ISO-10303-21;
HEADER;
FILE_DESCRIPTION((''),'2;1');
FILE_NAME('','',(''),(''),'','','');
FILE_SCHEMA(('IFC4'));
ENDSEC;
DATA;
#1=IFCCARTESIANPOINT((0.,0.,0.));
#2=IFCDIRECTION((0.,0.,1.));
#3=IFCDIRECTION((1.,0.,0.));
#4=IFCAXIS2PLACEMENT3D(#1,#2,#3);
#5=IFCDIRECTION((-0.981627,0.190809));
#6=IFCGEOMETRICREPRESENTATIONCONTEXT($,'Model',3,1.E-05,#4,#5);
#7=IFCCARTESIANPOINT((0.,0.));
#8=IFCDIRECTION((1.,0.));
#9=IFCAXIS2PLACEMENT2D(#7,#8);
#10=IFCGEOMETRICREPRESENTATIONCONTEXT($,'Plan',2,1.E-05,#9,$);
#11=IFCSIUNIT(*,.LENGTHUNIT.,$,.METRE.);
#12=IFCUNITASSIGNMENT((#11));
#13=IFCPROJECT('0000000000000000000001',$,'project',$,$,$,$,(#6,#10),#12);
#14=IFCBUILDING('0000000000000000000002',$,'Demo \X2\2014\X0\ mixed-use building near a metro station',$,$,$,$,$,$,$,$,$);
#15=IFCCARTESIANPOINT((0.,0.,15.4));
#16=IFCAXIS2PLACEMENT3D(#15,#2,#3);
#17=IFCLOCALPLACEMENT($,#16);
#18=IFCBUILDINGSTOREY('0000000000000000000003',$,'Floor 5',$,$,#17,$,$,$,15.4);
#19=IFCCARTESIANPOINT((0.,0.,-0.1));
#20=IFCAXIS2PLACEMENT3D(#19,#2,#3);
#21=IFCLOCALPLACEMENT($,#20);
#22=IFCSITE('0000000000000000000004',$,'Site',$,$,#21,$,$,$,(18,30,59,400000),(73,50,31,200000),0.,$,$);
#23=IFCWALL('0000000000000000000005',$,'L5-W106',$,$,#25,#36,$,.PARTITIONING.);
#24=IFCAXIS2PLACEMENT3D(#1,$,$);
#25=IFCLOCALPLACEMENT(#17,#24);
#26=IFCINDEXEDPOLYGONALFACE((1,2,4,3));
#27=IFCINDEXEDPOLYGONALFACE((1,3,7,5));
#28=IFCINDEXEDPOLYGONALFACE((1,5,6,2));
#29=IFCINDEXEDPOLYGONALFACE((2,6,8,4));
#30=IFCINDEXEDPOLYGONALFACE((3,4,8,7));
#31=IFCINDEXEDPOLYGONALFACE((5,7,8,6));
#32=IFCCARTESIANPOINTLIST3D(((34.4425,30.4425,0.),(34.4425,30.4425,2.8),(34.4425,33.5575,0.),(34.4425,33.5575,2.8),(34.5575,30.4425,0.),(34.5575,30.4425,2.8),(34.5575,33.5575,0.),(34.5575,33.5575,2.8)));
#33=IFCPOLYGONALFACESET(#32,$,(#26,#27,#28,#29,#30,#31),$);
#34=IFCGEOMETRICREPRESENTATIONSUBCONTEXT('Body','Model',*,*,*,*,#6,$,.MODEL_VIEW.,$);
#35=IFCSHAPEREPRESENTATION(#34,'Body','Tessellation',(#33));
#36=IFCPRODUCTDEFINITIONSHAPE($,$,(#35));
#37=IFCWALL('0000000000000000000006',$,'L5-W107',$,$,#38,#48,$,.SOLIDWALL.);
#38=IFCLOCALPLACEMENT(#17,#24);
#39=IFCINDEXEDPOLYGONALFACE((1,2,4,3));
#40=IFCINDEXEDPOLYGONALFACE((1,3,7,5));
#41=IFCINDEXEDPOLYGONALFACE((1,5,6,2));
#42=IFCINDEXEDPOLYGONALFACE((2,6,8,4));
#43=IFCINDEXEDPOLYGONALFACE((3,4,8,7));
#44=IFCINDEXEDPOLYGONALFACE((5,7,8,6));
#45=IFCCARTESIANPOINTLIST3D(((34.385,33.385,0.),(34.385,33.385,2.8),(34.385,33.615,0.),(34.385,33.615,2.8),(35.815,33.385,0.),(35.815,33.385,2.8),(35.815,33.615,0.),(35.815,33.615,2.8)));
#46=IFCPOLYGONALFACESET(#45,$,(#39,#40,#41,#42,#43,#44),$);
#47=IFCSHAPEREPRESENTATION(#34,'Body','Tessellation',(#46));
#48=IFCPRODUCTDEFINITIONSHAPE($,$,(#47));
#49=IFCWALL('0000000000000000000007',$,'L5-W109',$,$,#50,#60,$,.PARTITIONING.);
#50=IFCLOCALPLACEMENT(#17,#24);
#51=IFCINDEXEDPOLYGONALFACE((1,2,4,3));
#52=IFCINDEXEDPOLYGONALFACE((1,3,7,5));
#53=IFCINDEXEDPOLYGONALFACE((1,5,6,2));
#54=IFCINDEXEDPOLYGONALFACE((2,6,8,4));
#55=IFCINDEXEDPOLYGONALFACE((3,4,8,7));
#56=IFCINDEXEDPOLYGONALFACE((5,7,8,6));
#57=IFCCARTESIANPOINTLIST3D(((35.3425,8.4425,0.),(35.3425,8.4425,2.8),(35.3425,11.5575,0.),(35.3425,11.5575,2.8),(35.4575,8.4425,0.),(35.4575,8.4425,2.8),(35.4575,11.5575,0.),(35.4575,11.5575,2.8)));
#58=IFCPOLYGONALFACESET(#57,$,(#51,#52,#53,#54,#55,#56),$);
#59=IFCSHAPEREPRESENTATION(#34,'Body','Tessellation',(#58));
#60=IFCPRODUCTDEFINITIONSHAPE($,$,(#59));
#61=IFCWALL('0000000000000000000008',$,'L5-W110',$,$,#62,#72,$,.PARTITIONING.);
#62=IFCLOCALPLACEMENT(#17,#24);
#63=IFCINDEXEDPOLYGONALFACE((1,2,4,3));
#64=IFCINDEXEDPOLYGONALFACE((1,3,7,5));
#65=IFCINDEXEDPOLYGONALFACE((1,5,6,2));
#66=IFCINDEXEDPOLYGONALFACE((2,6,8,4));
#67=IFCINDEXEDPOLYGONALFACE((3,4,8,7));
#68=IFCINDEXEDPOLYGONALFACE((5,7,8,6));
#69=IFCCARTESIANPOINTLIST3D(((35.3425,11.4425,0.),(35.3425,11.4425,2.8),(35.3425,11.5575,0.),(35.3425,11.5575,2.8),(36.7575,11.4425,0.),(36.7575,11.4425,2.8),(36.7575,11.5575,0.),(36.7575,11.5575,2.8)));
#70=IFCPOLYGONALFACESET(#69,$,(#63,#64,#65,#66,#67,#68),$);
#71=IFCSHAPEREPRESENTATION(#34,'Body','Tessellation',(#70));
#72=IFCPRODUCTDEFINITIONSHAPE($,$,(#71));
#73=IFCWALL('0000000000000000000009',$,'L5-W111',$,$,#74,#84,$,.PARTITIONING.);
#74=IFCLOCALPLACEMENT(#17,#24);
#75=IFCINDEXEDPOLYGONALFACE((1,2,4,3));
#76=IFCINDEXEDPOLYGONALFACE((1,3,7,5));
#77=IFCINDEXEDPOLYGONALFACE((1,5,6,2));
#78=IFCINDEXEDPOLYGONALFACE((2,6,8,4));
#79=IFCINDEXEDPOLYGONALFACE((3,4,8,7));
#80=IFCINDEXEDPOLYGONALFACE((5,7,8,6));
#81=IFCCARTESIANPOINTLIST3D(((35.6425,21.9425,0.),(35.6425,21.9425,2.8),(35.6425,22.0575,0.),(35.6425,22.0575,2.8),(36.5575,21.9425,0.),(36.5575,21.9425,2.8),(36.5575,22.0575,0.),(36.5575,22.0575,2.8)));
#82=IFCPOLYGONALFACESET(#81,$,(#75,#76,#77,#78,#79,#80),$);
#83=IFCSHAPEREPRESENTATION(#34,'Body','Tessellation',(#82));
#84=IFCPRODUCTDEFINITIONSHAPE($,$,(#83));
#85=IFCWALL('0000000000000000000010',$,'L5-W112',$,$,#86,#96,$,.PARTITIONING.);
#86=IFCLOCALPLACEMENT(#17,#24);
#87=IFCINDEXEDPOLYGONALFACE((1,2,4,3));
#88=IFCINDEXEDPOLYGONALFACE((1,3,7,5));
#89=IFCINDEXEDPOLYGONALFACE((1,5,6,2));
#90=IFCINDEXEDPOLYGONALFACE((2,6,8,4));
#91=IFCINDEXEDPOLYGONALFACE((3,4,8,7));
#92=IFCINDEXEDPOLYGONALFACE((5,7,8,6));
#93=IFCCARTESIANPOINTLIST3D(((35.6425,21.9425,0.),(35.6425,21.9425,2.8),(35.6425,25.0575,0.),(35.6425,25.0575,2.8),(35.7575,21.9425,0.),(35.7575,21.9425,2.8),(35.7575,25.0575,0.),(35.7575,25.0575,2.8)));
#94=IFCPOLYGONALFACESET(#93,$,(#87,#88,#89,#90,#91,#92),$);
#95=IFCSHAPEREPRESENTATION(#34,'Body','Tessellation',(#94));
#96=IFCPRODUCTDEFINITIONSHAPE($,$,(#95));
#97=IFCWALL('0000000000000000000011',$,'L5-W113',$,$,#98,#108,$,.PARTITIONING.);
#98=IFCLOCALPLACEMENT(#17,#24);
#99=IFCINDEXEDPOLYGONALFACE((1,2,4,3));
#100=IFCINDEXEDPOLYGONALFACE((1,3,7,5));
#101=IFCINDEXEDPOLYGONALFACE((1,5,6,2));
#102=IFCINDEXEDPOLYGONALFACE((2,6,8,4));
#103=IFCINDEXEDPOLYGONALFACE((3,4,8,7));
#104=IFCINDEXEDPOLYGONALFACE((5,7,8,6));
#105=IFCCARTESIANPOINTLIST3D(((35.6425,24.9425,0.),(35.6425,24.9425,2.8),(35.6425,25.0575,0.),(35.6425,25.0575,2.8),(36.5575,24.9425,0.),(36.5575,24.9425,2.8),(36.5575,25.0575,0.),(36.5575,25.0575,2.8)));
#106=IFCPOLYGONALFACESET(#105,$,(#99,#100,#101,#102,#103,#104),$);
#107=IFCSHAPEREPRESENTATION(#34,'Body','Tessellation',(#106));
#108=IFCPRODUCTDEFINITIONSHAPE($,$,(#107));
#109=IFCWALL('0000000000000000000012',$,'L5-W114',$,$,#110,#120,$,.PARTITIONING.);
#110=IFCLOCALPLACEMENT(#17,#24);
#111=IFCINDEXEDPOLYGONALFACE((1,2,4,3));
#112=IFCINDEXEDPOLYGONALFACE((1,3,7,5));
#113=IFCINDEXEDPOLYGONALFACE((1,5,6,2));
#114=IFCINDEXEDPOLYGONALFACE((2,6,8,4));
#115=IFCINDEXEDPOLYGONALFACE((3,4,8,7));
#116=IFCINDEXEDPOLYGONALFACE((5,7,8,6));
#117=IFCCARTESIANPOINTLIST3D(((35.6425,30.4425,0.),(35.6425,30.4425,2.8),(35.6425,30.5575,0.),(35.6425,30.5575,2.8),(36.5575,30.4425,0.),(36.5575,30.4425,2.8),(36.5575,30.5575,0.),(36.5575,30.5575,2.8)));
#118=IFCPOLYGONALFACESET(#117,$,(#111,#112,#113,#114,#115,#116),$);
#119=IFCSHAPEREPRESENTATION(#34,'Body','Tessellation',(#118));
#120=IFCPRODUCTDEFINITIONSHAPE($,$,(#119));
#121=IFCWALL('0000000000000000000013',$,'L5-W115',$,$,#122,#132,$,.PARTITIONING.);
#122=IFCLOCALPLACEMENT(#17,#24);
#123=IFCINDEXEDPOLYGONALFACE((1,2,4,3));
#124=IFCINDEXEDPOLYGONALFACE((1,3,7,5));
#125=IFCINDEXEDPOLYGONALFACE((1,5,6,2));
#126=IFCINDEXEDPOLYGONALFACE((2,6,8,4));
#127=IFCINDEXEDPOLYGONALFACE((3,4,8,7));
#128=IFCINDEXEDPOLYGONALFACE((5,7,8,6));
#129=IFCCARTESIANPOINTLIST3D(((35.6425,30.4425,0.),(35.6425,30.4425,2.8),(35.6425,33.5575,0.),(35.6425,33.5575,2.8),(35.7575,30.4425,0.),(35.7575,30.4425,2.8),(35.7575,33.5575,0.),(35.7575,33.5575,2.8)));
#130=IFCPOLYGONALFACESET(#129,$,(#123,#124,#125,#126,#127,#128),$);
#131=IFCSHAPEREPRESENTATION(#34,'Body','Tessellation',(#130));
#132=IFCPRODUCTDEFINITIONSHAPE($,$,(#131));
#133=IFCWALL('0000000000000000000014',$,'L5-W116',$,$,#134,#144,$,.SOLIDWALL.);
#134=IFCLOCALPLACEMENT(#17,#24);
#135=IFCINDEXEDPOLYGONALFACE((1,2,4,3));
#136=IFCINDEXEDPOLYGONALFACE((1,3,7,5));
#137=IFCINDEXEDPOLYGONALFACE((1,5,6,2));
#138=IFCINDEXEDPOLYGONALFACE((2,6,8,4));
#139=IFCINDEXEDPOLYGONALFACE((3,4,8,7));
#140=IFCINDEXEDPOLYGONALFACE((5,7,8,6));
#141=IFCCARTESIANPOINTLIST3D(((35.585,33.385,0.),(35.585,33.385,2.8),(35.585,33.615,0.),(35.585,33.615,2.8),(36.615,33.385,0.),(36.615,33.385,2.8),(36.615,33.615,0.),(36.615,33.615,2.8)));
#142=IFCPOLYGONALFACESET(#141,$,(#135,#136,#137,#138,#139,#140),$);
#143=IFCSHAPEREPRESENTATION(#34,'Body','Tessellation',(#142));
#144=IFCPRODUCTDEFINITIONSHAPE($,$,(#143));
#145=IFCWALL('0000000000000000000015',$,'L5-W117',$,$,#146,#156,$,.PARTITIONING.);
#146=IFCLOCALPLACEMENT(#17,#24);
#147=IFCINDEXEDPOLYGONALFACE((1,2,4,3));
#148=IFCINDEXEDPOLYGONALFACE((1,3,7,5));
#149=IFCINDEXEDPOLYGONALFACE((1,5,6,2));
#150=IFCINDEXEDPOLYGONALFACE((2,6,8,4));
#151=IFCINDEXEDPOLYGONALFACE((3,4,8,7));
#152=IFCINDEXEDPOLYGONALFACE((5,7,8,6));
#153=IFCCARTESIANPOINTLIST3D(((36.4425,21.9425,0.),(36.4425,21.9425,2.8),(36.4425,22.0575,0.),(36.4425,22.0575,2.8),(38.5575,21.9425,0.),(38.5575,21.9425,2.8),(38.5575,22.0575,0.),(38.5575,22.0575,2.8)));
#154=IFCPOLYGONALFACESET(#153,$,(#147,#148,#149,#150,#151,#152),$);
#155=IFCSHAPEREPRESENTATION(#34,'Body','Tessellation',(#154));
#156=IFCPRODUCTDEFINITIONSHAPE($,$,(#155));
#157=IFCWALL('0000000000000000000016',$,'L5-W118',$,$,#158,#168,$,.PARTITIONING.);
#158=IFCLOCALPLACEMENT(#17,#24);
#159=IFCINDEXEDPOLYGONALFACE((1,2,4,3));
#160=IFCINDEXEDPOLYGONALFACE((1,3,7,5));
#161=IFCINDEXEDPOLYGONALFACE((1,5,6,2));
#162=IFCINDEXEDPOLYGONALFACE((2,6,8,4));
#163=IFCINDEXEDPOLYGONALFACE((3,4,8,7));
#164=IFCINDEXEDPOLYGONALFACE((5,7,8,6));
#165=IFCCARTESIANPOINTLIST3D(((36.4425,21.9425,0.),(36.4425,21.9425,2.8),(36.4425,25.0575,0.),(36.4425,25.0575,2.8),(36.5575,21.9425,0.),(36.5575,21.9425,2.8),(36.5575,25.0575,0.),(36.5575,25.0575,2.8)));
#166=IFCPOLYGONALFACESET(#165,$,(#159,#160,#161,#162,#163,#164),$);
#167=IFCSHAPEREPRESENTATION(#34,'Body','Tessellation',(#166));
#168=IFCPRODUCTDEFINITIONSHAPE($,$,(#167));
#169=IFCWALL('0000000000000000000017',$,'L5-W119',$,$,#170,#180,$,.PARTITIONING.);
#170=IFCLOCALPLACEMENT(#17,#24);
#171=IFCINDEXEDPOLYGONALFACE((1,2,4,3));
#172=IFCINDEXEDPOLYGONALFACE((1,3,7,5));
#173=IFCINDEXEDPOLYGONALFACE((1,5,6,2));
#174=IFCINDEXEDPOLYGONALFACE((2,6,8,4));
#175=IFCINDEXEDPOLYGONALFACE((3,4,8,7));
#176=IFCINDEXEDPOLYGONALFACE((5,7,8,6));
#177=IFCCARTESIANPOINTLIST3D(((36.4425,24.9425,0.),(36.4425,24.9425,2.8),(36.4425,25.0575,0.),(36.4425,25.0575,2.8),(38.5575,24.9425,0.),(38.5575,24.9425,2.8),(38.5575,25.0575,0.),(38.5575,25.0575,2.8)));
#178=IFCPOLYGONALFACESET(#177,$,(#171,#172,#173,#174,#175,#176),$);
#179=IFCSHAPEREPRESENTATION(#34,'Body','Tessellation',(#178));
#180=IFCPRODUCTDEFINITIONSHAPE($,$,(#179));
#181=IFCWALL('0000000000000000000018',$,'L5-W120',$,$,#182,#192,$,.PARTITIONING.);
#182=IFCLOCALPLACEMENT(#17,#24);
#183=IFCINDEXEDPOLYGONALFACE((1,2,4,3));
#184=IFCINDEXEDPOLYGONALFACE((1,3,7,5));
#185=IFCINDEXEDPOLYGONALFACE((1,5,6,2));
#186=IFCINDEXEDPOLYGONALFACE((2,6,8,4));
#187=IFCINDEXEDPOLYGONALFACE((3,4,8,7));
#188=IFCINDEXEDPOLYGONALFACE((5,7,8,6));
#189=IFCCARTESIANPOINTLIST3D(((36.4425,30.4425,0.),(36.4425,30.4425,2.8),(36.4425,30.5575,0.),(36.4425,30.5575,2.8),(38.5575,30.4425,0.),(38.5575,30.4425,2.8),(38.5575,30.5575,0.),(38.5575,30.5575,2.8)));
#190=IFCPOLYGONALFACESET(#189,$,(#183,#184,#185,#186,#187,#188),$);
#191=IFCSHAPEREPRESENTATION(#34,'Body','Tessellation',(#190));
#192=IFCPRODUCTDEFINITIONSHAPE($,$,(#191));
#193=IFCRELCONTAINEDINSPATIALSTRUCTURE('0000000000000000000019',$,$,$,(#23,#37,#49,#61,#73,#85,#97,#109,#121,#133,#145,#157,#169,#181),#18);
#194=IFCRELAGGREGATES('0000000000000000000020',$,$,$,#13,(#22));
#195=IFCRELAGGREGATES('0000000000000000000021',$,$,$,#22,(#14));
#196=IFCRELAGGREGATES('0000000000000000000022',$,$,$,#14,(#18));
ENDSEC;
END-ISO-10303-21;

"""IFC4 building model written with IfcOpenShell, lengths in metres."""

from ifc_helpers import new_model, si_unit, direction, frame, origin_with_axes, origin_2d_with_axis, place, context, subcontext, project, spatial, line, indexed_curve, outline, extrude, element, save


model = new_model("IFC4")

# Units and contexts
model_context = context("Model", 3, precision=1e-05, world=origin_with_axes(), true_north=direction((-0.981627, 0.190809)))
plan_context = context("Plan", 2, precision=1e-05, world=origin_2d_with_axis())
body_context = subcontext(model_context, "Body", "Model", "MODEL_VIEW")
ifc_project = project(units=[si_unit("LENGTHUNIT", "METRE")], contexts=[model_context, plan_context])

# Site, building, storey
site_placement = place(None, frame((0.0, 0.0, -0.1), z_axis=(0.0, 0.0, 1.0), x_axis=(1.0, 0.0, 0.0)))
site = spatial("IfcSite", under=ifc_project, at=site_placement, Name="Site", RefLatitude=(18, 30, 59, 400000), RefLongitude=(73, 50, 31, 200000), RefElevation=0.0)
building = spatial("IfcBuilding", under=site, Name="Demo — mixed-use building near a metro station")
storey_placement = place(None, frame((0.0, 0.0, 15.4), z_axis=(0.0, 0.0, 1.0), x_axis=(1.0, 0.0, 0.0)))
storey = spatial("IfcBuildingStorey", under=building, at=storey_placement, Name="Floor 5", Elevation=15.4)

# Walls
wall_1_placement = place(storey_placement, frame((0.0, 0.0, -15.4), z_axis=(0.0, 0.0, 1.0), x_axis=(1.0, 0.0, 0.0)))
element("IfcWall", 1, at=wall_1_placement, inside=storey, Name="L5-W106", PredefinedType="PARTITIONING", context=body_context, shape_type="SweptSolid", body=[
    extrude(outline(indexed_curve([(34.4425, 30.4425), (34.4425, 33.5575), (34.5575, 33.5575), (34.5575, 30.4425)], segments=[line(1, 2, 3, 4, 1)])), frame((0.0, 0.0, 15.4), z_axis=(0.0, 0.0, 1.0), x_axis=(1.0, 0.0, 0.0)), (0.0, 0.0, 1.0), 2.8),
])
wall_2_placement = place(storey_placement, frame((0.0, 0.0, -15.4), z_axis=(0.0, 0.0, 1.0), x_axis=(1.0, 0.0, 0.0)))
element("IfcWall", 2, at=wall_2_placement, inside=storey, Name="L5-W107", PredefinedType="SOLIDWALL", context=body_context, shape_type="SweptSolid", body=[
    extrude(outline(indexed_curve([(35.815, 33.385), (34.385, 33.385), (34.385, 33.615), (35.815, 33.615)], segments=[line(1, 2, 3, 4, 1)])), frame((0.0, 0.0, 15.4), z_axis=(0.0, 0.0, 1.0), x_axis=(1.0, 0.0, 0.0)), (0.0, 0.0, 1.0), 2.8),
])

# Walls
wall_3_placement = place(storey_placement, frame((0.0, 0.0, -15.4), z_axis=(0.0, 0.0, 1.0), x_axis=(1.0, 0.0, 0.0)))
element("IfcWall", 3, at=wall_3_placement, inside=storey, Name="L5-W109", PredefinedType="PARTITIONING", context=body_context, shape_type="SweptSolid", body=[
    extrude(outline(indexed_curve([(35.4575, 11.5575), (35.4575, 8.4425), (35.3425, 8.4425), (35.3425, 11.5575)], segments=[line(1, 2, 3, 4, 1)])), frame((0.0, 0.0, 15.4), z_axis=(0.0, 0.0, 1.0), x_axis=(1.0, 0.0, 0.0)), (0.0, 0.0, 1.0), 2.8),
])
wall_4_placement = place(storey_placement, frame((0.0, 0.0, -15.4), z_axis=(0.0, 0.0, 1.0), x_axis=(1.0, 0.0, 0.0)))
element("IfcWall", 4, at=wall_4_placement, inside=storey, Name="L5-W110", PredefinedType="PARTITIONING", context=body_context, shape_type="SweptSolid", body=[
    extrude(outline(indexed_curve([(35.3425, 11.5575), (36.7575, 11.5575), (36.7575, 11.4425), (35.3425, 11.4425)], segments=[line(1, 2, 3, 4, 1)])), frame((0.0, 0.0, 15.4), z_axis=(0.0, 0.0, 1.0), x_axis=(1.0, 0.0, 0.0)), (0.0, 0.0, 1.0), 2.8),
])
wall_5_placement = place(storey_placement, frame((0.0, 0.0, -15.4), z_axis=(0.0, 0.0, 1.0), x_axis=(1.0, 0.0, 0.0)))
element("IfcWall", 5, at=wall_5_placement, inside=storey, Name="L5-W111", PredefinedType="PARTITIONING", context=body_context, shape_type="SweptSolid", body=[
    extrude(outline(indexed_curve([(36.5575, 21.9425), (35.6425, 21.9425), (35.6425, 22.0575), (36.5575, 22.0575)], segments=[line(1, 2, 3, 4, 1)])), frame((0.0, 0.0, 15.4), z_axis=(0.0, 0.0, 1.0), x_axis=(1.0, 0.0, 0.0)), (0.0, 0.0, 1.0), 2.8),
])
wall_6_placement = place(storey_placement, frame((0.0, 0.0, -15.4), z_axis=(0.0, 0.0, 1.0), x_axis=(1.0, 0.0, 0.0)))
element("IfcWall", 6, at=wall_6_placement, inside=storey, Name="L5-W112", PredefinedType="PARTITIONING", context=body_context, shape_type="SweptSolid", body=[
    extrude(outline(indexed_curve([(35.7575, 25.0575), (35.7575, 21.9425), (35.6425, 21.9425), (35.6425, 25.0575)], segments=[line(1, 2, 3, 4, 1)])), frame((0.0, 0.0, 15.4), z_axis=(0.0, 0.0, 1.0), x_axis=(1.0, 0.0, 0.0)), (0.0, 0.0, 1.0), 2.8),
])
wall_7_placement = place(storey_placement, frame((0.0, 0.0, -15.4), z_axis=(0.0, 0.0, 1.0), x_axis=(1.0, 0.0, 0.0)))
element("IfcWall", 7, at=wall_7_placement, inside=storey, Name="L5-W113", PredefinedType="PARTITIONING", context=body_context, shape_type="SweptSolid", body=[
    extrude(outline(indexed_curve([(36.5575, 24.9425), (35.6425, 24.9425), (35.6425, 25.0575), (36.5575, 25.0575)], segments=[line(1, 2, 3, 4, 1)])), frame((0.0, 0.0, 15.4), z_axis=(0.0, 0.0, 1.0), x_axis=(1.0, 0.0, 0.0)), (0.0, 0.0, 1.0), 2.8),
])
wall_8_placement = place(storey_placement, frame((0.0, 0.0, -15.4), z_axis=(0.0, 0.0, 1.0), x_axis=(1.0, 0.0, 0.0)))
element("IfcWall", 8, at=wall_8_placement, inside=storey, Name="L5-W114", PredefinedType="PARTITIONING", context=body_context, shape_type="SweptSolid", body=[
    extrude(outline(indexed_curve([(36.5575, 30.4425), (35.6425, 30.4425), (35.6425, 30.5575), (36.5575, 30.5575)], segments=[line(1, 2, 3, 4, 1)])), frame((0.0, 0.0, 15.4), z_axis=(0.0, 0.0, 1.0), x_axis=(1.0, 0.0, 0.0)), (0.0, 0.0, 1.0), 2.8),
])
wall_9_placement = place(storey_placement, frame((0.0, 0.0, -15.4), z_axis=(0.0, 0.0, 1.0), x_axis=(1.0, 0.0, 0.0)))
element("IfcWall", 9, at=wall_9_placement, inside=storey, Name="L5-W115", PredefinedType="PARTITIONING", context=body_context, shape_type="SweptSolid", body=[
    extrude(outline(indexed_curve([(35.7575, 33.5575), (35.7575, 30.4425), (35.6425, 30.4425), (35.6425, 33.5575)], segments=[line(1, 2, 3, 4, 1)])), frame((0.0, 0.0, 15.4), z_axis=(0.0, 0.0, 1.0), x_axis=(1.0, 0.0, 0.0)), (0.0, 0.0, 1.0), 2.8),
])
wall_10_placement = place(storey_placement, frame((0.0, 0.0, -15.4), z_axis=(0.0, 0.0, 1.0), x_axis=(1.0, 0.0, 0.0)))
element("IfcWall", 10, at=wall_10_placement, inside=storey, Name="L5-W116", PredefinedType="SOLIDWALL", context=body_context, shape_type="SweptSolid", body=[
    extrude(outline(indexed_curve([(36.615, 33.385), (35.585, 33.385), (35.585, 33.615), (36.615, 33.615)], segments=[line(1, 2, 3, 4, 1)])), frame((0.0, 0.0, 15.4), z_axis=(0.0, 0.0, 1.0), x_axis=(1.0, 0.0, 0.0)), (0.0, 0.0, 1.0), 2.8),
])
wall_11_placement = place(storey_placement, frame((0.0, 0.0, -15.4), z_axis=(0.0, 0.0, 1.0), x_axis=(1.0, 0.0, 0.0)))
element("IfcWall", 11, at=wall_11_placement, inside=storey, Name="L5-W117", PredefinedType="PARTITIONING", context=body_context, shape_type="SweptSolid", body=[
    extrude(outline(indexed_curve([(38.5575, 21.9425), (36.4425, 21.9425), (36.4425, 22.0575), (38.5575, 22.0575)], segments=[line(1, 2, 3, 4, 1)])), frame((0.0, 0.0, 15.4), z_axis=(0.0, 0.0, 1.0), x_axis=(1.0, 0.0, 0.0)), (0.0, 0.0, 1.0), 2.8),
])
wall_12_placement = place(storey_placement, frame((0.0, 0.0, -15.4), z_axis=(0.0, 0.0, 1.0), x_axis=(1.0, 0.0, 0.0)))
element("IfcWall", 12, at=wall_12_placement, inside=storey, Name="L5-W118", PredefinedType="PARTITIONING", context=body_context, shape_type="SweptSolid", body=[
    extrude(outline(indexed_curve([(36.5575, 25.0575), (36.5575, 21.9425), (36.4425, 21.9425), (36.4425, 25.0575)], segments=[line(1, 2, 3, 4, 1)])), frame((0.0, 0.0, 15.4), z_axis=(0.0, 0.0, 1.0), x_axis=(1.0, 0.0, 0.0)), (0.0, 0.0, 1.0), 2.8),
])
wall_13_placement = place(storey_placement, frame((0.0, 0.0, -15.4), z_axis=(0.0, 0.0, 1.0), x_axis=(1.0, 0.0, 0.0)))
element("IfcWall", 13, at=wall_13_placement, inside=storey, Name="L5-W119", PredefinedType="PARTITIONING", context=body_context, shape_type="SweptSolid", body=[
    extrude(outline(indexed_curve([(38.5575, 24.9425), (36.4425, 24.9425), (36.4425, 25.0575), (38.5575, 25.0575)], segments=[line(1, 2, 3, 4, 1)])), frame((0.0, 0.0, 15.4), z_axis=(0.0, 0.0, 1.0), x_axis=(1.0, 0.0, 0.0)), (0.0, 0.0, 1.0), 2.8),
])
wall_14_placement = place(storey_placement, frame((0.0, 0.0, -15.4), z_axis=(0.0, 0.0, 1.0), x_axis=(1.0, 0.0, 0.0)))
element("IfcWall", 14, at=wall_14_placement, inside=storey, Name="L5-W120", PredefinedType="PARTITIONING", context=body_context, shape_type="SweptSolid", body=[
    extrude(outline(indexed_curve([(38.5575, 30.4425), (36.4425, 30.4425), (36.4425, 30.5575), (38.5575, 30.5575)], segments=[line(1, 2, 3, 4, 1)])), frame((0.0, 0.0, 15.4), z_axis=(0.0, 0.0, 1.0), x_axis=(1.0, 0.0, 0.0)), (0.0, 0.0, 1.0), 2.8),
])

save(model, "model.ifc")
